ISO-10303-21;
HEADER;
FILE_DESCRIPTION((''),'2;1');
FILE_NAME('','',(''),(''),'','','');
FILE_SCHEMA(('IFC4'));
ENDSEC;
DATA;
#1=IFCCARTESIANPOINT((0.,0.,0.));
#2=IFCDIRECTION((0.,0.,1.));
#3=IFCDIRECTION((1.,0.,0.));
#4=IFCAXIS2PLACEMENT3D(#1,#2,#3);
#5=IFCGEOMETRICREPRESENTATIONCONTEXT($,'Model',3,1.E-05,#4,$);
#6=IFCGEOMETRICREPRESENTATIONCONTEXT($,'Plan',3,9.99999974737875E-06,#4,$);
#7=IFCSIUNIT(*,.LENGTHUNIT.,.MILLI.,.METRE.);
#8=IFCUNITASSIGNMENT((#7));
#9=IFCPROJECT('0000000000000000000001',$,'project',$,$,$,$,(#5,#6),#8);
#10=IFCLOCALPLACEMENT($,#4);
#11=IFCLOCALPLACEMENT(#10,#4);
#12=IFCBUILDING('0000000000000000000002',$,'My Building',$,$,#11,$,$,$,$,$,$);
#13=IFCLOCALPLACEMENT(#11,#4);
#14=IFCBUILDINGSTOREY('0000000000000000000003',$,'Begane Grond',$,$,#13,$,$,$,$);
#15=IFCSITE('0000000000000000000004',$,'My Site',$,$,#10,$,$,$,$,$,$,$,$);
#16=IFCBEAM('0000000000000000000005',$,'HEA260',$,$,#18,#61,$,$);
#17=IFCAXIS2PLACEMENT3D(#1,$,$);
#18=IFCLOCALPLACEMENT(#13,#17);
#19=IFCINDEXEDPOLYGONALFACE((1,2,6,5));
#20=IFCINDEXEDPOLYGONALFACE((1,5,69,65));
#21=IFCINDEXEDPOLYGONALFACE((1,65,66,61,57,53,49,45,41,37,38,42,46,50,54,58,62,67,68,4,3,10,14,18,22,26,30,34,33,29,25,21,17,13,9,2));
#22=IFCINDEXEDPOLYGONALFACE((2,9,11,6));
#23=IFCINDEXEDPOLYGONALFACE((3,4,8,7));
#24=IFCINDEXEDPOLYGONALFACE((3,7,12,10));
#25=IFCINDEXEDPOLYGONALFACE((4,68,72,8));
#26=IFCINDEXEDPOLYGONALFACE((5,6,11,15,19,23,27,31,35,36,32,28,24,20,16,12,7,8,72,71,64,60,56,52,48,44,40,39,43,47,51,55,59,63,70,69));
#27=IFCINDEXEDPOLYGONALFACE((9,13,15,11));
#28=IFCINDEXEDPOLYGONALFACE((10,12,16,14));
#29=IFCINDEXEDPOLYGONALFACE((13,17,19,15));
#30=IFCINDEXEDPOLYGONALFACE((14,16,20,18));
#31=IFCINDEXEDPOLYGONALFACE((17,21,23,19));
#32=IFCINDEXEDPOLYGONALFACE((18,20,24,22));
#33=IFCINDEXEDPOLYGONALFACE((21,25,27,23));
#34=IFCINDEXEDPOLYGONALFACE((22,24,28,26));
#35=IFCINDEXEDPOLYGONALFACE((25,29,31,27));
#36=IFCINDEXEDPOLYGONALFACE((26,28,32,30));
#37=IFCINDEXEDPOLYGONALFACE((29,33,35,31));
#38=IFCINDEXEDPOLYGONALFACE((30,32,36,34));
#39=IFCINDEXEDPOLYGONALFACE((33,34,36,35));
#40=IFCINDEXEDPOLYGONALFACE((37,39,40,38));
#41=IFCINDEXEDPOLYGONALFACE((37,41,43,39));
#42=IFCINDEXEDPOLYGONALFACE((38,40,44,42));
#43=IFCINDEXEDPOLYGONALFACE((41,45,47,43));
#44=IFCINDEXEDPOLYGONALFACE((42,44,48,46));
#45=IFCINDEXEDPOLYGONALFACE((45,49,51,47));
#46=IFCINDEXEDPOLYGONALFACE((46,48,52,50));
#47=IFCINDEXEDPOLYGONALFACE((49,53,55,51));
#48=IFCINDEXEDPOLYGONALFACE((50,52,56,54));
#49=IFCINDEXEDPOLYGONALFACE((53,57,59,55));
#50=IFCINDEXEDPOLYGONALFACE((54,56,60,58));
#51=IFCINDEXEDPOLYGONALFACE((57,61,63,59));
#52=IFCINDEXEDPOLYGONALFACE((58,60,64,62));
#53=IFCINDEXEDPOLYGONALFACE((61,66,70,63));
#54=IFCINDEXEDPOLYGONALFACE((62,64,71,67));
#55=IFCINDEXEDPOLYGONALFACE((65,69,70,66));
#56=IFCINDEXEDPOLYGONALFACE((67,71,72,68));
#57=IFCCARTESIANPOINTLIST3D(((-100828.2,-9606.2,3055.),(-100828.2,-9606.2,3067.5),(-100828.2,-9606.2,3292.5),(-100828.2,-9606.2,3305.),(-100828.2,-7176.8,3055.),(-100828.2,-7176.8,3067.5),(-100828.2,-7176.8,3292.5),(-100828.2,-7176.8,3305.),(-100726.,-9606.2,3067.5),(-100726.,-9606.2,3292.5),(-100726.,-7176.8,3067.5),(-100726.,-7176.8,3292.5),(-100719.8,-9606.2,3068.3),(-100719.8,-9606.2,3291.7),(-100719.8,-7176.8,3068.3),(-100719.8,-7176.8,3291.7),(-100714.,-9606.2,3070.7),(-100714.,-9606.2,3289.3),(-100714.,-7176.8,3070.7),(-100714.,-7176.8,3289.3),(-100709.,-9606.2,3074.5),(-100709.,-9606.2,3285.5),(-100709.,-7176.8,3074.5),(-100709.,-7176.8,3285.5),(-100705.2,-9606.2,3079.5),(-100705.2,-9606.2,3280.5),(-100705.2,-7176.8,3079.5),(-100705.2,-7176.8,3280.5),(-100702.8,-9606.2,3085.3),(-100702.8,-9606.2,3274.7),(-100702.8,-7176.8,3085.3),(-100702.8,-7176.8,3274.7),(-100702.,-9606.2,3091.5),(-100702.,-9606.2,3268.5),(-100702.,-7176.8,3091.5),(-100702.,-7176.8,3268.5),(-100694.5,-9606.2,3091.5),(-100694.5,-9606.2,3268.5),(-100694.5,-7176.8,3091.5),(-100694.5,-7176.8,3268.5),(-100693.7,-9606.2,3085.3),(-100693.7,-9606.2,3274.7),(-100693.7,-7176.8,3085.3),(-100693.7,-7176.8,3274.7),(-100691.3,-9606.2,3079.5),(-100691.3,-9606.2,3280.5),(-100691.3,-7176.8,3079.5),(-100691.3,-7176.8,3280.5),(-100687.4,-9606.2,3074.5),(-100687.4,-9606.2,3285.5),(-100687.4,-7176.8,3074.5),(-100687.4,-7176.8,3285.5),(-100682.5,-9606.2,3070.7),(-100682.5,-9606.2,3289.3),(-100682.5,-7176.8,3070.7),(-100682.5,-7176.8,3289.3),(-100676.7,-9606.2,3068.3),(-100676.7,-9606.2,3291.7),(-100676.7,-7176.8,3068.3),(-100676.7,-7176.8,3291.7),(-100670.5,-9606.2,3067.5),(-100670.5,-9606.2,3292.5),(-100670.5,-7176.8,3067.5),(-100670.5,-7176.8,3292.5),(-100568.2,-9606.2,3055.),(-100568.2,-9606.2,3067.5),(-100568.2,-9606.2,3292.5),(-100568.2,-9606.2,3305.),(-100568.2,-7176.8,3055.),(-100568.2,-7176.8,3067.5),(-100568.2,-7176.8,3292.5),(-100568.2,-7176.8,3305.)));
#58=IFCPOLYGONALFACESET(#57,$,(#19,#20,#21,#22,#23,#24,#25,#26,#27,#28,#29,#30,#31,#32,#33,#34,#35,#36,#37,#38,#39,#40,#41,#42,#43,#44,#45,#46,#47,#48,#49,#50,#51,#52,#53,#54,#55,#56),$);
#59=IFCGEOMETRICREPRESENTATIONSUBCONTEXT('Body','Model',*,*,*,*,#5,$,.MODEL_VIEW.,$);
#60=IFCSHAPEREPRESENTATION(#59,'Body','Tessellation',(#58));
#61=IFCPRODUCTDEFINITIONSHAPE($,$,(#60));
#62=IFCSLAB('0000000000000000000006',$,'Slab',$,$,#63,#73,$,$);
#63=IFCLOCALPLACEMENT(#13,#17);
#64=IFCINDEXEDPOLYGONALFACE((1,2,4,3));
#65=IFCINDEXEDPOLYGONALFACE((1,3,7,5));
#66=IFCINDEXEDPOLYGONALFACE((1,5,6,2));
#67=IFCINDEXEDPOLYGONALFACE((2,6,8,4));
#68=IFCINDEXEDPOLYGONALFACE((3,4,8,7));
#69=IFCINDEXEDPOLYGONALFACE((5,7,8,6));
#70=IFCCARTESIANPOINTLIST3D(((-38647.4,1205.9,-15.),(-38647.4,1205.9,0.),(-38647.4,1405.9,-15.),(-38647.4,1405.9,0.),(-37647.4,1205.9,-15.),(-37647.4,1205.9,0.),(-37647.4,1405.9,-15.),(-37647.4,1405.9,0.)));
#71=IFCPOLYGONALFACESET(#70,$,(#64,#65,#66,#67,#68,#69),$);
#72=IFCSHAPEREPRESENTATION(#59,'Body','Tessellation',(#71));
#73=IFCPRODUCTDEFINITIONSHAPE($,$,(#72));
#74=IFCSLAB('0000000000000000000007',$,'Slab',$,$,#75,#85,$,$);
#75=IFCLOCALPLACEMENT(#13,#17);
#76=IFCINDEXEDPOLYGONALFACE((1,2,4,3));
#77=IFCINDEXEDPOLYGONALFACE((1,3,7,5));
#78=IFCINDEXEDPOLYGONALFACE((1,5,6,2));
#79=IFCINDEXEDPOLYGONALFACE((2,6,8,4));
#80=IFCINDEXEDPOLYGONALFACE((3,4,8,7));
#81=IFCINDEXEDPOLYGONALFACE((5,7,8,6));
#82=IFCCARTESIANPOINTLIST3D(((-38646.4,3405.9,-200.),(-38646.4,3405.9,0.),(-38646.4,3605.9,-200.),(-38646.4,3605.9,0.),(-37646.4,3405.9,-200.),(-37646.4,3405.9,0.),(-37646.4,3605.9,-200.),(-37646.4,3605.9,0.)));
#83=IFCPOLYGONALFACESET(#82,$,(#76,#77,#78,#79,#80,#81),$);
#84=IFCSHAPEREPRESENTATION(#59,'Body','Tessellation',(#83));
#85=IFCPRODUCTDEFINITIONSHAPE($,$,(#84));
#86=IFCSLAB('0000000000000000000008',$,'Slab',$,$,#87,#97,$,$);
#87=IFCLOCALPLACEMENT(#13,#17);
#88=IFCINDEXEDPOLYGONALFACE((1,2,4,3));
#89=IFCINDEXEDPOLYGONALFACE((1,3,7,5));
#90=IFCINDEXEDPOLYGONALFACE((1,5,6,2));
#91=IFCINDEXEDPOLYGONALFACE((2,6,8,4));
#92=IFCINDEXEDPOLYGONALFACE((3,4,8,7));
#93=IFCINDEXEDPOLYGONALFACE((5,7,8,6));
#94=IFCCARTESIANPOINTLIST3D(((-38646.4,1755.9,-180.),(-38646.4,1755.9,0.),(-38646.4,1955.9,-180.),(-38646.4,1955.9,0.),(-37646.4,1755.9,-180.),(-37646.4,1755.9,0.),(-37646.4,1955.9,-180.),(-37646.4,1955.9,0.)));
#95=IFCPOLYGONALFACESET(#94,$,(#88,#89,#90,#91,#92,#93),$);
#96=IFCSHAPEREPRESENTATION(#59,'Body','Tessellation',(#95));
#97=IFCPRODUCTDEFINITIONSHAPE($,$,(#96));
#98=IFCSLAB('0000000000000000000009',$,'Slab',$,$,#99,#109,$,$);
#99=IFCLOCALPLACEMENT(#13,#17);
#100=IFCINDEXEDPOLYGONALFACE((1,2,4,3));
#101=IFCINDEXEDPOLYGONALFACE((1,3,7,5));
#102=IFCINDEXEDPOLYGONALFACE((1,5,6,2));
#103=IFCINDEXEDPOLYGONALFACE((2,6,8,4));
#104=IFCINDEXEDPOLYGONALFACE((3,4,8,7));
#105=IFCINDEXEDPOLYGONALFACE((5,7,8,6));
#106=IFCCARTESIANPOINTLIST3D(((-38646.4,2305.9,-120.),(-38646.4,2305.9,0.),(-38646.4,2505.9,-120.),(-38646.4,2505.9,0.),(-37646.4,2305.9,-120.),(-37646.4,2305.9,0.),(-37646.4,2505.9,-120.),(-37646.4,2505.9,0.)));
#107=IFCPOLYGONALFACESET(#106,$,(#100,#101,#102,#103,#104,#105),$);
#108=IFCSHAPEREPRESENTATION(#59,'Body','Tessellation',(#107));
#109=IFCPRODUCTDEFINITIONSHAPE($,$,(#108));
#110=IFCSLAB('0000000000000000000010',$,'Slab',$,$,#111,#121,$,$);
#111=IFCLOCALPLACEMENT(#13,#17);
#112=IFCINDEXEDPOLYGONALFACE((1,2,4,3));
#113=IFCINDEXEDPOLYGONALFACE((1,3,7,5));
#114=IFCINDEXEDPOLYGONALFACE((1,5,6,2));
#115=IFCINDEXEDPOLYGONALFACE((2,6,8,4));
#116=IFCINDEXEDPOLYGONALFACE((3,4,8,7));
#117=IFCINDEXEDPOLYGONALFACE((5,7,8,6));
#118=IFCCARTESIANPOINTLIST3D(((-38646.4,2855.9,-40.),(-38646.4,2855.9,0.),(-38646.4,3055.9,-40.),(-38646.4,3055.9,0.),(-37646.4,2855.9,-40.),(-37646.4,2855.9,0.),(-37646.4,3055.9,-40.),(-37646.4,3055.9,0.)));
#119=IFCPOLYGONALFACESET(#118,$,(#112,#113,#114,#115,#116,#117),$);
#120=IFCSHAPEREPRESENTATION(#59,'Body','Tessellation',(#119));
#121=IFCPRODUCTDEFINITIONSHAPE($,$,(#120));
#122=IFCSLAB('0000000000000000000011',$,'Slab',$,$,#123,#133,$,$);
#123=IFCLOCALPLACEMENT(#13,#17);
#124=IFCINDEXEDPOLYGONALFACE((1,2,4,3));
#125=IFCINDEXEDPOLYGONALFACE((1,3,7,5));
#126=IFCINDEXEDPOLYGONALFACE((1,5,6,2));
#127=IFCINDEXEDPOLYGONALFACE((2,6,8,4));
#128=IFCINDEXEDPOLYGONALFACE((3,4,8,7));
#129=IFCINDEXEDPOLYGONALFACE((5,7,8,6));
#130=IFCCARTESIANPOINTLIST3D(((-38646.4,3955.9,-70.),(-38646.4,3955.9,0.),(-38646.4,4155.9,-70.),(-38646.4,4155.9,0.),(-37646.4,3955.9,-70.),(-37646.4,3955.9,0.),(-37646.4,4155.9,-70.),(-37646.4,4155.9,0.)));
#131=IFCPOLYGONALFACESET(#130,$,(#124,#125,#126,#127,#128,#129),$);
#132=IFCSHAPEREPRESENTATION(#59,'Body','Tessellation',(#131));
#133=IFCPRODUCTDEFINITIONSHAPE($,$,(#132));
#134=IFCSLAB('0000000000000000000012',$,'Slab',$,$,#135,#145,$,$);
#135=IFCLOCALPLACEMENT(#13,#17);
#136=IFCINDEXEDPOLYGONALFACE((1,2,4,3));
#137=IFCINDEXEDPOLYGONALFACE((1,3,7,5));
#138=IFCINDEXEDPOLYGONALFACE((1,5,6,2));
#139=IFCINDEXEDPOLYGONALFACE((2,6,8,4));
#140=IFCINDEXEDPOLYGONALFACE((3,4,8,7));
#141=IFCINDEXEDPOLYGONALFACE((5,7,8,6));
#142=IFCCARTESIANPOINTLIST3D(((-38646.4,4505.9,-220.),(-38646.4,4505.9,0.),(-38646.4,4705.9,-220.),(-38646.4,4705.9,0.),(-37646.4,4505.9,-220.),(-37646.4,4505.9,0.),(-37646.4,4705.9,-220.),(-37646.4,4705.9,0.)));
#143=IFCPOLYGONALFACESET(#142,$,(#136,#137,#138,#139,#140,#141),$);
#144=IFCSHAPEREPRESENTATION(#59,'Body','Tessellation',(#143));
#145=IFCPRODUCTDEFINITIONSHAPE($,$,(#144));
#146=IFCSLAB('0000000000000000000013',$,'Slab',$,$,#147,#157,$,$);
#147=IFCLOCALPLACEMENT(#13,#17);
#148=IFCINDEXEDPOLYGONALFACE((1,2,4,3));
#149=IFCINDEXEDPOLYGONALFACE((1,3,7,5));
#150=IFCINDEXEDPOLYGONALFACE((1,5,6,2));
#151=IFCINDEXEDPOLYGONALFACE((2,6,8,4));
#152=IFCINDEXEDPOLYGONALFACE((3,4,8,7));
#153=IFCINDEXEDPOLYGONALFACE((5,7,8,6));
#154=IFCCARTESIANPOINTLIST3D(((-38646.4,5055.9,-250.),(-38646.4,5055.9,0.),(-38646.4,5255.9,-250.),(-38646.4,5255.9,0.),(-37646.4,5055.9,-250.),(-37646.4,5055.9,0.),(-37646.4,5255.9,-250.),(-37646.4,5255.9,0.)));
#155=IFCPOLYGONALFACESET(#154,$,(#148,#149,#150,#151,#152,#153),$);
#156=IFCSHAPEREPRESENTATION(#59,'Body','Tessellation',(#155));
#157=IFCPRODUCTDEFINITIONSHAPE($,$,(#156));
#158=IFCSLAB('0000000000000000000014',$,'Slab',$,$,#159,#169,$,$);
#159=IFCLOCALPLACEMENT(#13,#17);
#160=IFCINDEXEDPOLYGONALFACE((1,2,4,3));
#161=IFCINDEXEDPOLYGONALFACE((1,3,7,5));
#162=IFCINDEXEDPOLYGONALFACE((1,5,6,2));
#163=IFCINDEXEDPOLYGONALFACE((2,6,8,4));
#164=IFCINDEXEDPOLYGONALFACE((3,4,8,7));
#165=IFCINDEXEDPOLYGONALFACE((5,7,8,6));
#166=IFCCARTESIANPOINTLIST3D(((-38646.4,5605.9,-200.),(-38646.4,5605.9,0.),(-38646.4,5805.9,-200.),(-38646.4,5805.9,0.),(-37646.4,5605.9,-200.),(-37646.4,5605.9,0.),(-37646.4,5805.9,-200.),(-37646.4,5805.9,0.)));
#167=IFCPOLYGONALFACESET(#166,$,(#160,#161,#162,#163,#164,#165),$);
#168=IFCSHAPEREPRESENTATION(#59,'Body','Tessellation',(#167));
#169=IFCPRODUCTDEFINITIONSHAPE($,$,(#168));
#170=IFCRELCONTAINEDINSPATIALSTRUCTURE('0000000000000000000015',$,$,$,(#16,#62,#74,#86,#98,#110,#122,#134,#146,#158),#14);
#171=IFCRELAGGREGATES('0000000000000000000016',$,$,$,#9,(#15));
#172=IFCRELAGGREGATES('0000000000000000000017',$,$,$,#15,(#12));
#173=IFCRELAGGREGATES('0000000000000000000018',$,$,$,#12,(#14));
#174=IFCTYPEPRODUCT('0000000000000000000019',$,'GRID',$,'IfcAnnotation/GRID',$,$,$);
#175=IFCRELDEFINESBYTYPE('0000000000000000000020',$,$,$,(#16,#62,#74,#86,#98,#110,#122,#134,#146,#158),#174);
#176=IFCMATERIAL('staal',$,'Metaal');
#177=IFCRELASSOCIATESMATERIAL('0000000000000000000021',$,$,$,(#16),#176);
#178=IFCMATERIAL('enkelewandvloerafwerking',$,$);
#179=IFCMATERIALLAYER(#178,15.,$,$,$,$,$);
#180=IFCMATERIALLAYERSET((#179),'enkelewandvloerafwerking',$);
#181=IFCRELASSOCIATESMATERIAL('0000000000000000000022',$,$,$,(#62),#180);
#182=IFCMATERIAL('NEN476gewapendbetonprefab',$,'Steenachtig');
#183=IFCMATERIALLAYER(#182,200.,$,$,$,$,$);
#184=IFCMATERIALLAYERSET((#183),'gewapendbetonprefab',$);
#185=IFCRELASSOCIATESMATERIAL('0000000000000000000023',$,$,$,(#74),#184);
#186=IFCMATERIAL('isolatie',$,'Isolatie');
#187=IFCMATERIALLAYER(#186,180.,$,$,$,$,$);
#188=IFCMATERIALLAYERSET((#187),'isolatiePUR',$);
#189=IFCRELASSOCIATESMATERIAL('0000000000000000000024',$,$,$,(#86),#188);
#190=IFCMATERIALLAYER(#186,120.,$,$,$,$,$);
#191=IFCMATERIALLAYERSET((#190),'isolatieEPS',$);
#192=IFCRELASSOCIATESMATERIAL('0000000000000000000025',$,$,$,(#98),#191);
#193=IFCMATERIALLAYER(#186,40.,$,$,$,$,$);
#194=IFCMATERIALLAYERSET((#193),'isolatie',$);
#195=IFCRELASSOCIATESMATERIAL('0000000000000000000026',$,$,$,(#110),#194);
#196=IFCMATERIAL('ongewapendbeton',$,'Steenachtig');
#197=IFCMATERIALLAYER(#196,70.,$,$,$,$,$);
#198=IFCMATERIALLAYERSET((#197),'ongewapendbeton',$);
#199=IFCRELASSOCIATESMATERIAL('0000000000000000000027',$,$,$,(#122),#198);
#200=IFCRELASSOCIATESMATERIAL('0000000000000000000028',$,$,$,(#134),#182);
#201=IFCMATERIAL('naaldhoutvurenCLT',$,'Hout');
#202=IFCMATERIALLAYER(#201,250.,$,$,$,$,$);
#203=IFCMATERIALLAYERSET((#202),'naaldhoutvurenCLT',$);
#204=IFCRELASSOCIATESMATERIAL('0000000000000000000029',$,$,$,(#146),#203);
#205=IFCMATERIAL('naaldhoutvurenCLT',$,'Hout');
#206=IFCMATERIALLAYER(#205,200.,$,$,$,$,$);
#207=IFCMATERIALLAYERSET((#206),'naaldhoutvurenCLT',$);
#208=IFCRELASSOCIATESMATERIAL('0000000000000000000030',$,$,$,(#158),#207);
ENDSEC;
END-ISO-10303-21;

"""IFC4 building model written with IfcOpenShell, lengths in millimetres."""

from ifc_helpers import new_model, si_unit, frame, origin_with_axes, place, context, subcontext, project, spatial, line, indexed_curve, i_section, outline, extrude, material, layer, layer_set, layer_usage, material_profile, profile_set, profile_usage, type_object, element, save


model = new_model("IFC4")

# Units and contexts
model_context = context("Model", 3, precision=1e-05, world=origin_with_axes())
plan_context = context("Plan", 3, precision=9.99999974737875e-06, world=origin_with_axes())
body_context = subcontext(model_context, "Body", "Model", "MODEL_VIEW")
ifc_project = project(units=[si_unit("LENGTHUNIT", "METRE", prefix="MILLI")], contexts=[model_context, plan_context])

# Site, building, storey
site_placement = place(None, frame((0.0, 0.0, 0.0), z_axis=(0.0, 0.0, 1.0), x_axis=(1.0, 0.0, 0.0)))
site = spatial("IfcSite", under=ifc_project, at=site_placement, Name="My Site")
building_placement = place(site_placement, origin_with_axes())
building = spatial("IfcBuilding", under=site, at=building_placement, Name="My Building")
storey_placement = place(building_placement, origin_with_axes())
storey = spatial("IfcBuildingStorey", under=building, at=storey_placement, Name="Begane Grond")

# Beam
ifc_material_1 = material(Name="staal", Category="Metaal")
ifc_material_profile = material_profile(ifc_material_1, i_section(OverallWidth=260.0, OverallDepth=250.0, WebThickness=7.5, FlangeThickness=12.5, FilletRadius=24.0))
ifc_profile_set = profile_set([ifc_material_profile], Name="HEA260")
ifc_profile_usage = profile_usage(ifc_profile_set, cardinal=5)
type_product = type_object("IfcTypeProduct", Name="GRID", ApplicableOccurrence="IfcAnnotation/GRID")
beam_placement = place(storey_placement, frame((-100698.2, -9606.2, 3180.0), z_axis=(0.0, 1.0, 0.0), x_axis=(-1.0, 0.0, 0.0)))
element("IfcBeam", 1, at=beam_placement, inside=storey, type_object=type_product, material=ifc_profile_usage, Name="HEA260", context=body_context, shape_type="SweptSolid", body=[
    extrude(i_section(OverallWidth=260.0, OverallDepth=250.0, WebThickness=7.5, FlangeThickness=12.5, FilletRadius=24.0), origin_with_axes(), (0.0, 0.0, 1.0), 2429.4),
])

# Slabs
ifc_material_2 = material(Name="naaldhoutvurenCLT", Category="Hout")
ifc_material_3 = material(Name="enkelewandvloerafwerking")
ifc_layer_1 = layer(ifc_material_3, 15.0)
ifc_layer_set_1 = layer_set([ifc_layer_1], Name="enkelewandvloerafwerking")
ifc_layer_usage_1 = layer_usage(ifc_layer_set_1, "AXIS3", "POSITIVE", 0.0)
slab_1_placement = place(storey_placement, frame((-38647.4, 1205.9, -15.0), z_axis=(0.0, 0.0, 1.0), x_axis=(1.0, 0.0, 0.0)))
element("IfcSlab", 2, at=slab_1_placement, inside=storey, type_object=type_product, material=ifc_layer_usage_1, Name="Slab", context=body_context, shape_type="SweptSolid", body=[
    extrude(outline(indexed_curve([(1000.0, 200.0), (1000.0, 0.0), (0.0, 0.0), (0.0, 200.0)], segments=[line(4, 1), line(1, 2), line(2, 3), line(3, 4)], self_intersect=False)), None, (0.0, 0.0, 1.0), 15.0),
])
ifc_material_4 = material(Name="NEN476gewapendbetonprefab", Category="Steenachtig")
ifc_layer_2 = layer(ifc_material_4, 200.0)
ifc_layer_set_2 = layer_set([ifc_layer_2], Name="gewapendbetonprefab")
ifc_layer_usage_2 = layer_usage(ifc_layer_set_2, "AXIS3", "POSITIVE", 0.0)
slab_2_placement = place(storey_placement, frame((-38646.4, 3405.9, -200.0), z_axis=(0.0, 0.0, 1.0), x_axis=(1.0, 0.0, 0.0)))
element("IfcSlab", 3, at=slab_2_placement, inside=storey, type_object=type_product, material=ifc_layer_usage_2, Name="Slab", context=body_context, shape_type="SweptSolid", body=[
    extrude(outline(indexed_curve([(1000.0, 200.0), (1000.0, 0.0), (0.0, 0.0), (0.0, 200.0)], segments=[line(4, 1), line(1, 2), line(2, 3), line(3, 4)], self_intersect=False)), None, (0.0, 0.0, 1.0), 200.0),
])
ifc_material_5 = material(Name="isolatie", Category="Isolatie")
ifc_layer_3 = layer(ifc_material_5, 180.0)
ifc_layer_set_3 = layer_set([ifc_layer_3], Name="isolatiePUR")
ifc_layer_usage_3 = layer_usage(ifc_layer_set_3, "AXIS3", "POSITIVE", 0.0)
slab_3_placement = place(storey_placement, frame((-38646.4, 1755.9, -180.0), z_axis=(0.0, 0.0, 1.0), x_axis=(1.0, 0.0, 0.0)))
element("IfcSlab", 4, at=slab_3_placement, inside=storey, type_object=type_product, material=ifc_layer_usage_3, Name="Slab", context=body_context, shape_type="SweptSolid", body=[
    extrude(outline(indexed_curve([(1000.0, 200.0), (1000.0, 0.0), (0.0, 0.0), (0.0, 200.0)], segments=[line(4, 1), line(1, 2), line(2, 3), line(3, 4)], self_intersect=False)), None, (0.0, 0.0, 1.0), 180.0),
])
ifc_layer_4 = layer(ifc_material_5, 120.0)
ifc_layer_set_4 = layer_set([ifc_layer_4], Name="isolatieEPS")
ifc_layer_usage_4 = layer_usage(ifc_layer_set_4, "AXIS3", "POSITIVE", 0.0)
slab_4_placement = place(storey_placement, frame((-38646.4, 2305.9, -120.0), z_axis=(0.0, 0.0, 1.0), x_axis=(1.0, 0.0, 0.0)))
element("IfcSlab", 5, at=slab_4_placement, inside=storey, type_object=type_product, material=ifc_layer_usage_4, Name="Slab", context=body_context, shape_type="SweptSolid", body=[
    extrude(outline(indexed_curve([(1000.0, 200.0), (1000.0, 0.0), (0.0, 0.0), (0.0, 200.0)], segments=[line(3, 2), line(2, 1), line(1, 4), line(4, 3)], self_intersect=False)), None, (0.0, 0.0, 1.0), 120.0),
])
ifc_layer_5 = layer(ifc_material_5, 40.0)
ifc_layer_set_5 = layer_set([ifc_layer_5], Name="isolatie")
ifc_layer_usage_5 = layer_usage(ifc_layer_set_5, "AXIS3", "POSITIVE", 0.0)
slab_5_placement = place(storey_placement, frame((-38646.4, 2855.9, -40.0), z_axis=(0.0, 0.0, 1.0), x_axis=(1.0, 0.0, 0.0)))
element("IfcSlab", 6, at=slab_5_placement, inside=storey, type_object=type_product, material=ifc_layer_usage_5, Name="Slab", context=body_context, shape_type="SweptSolid", body=[
    extrude(outline(indexed_curve([(1000.0, 200.0), (1000.0, 0.0), (0.0, 0.0), (0.0, 200.0)], segments=[line(3, 2), line(2, 1), line(1, 4), line(4, 3)], self_intersect=False)), None, (0.0, 0.0, 1.0), 40.0),
])
ifc_material_6 = material(Name="ongewapendbeton", Category="Steenachtig")
ifc_layer_6 = layer(ifc_material_6, 70.0)
ifc_layer_set_6 = layer_set([ifc_layer_6], Name="ongewapendbeton")
ifc_layer_usage_6 = layer_usage(ifc_layer_set_6, "AXIS3", "POSITIVE", 0.0)
slab_6_placement = place(storey_placement, frame((-38646.4, 3955.9, -70.0), z_axis=(0.0, 0.0, 1.0), x_axis=(1.0, 0.0, 0.0)))
element("IfcSlab", 7, at=slab_6_placement, inside=storey, type_object=type_product, material=ifc_layer_usage_6, Name="Slab", context=body_context, shape_type="SweptSolid", body=[
    extrude(outline(indexed_curve([(1000.0, 200.0), (1000.0, 0.0), (0.0, 0.0), (0.0, 200.0)], segments=[line(4, 1), line(1, 2), line(2, 3), line(3, 4)], self_intersect=False)), None, (0.0, 0.0, 1.0), 70.0),
])
slab_7_placement = place(storey_placement, frame((-38646.4, 4505.9, -220.0), z_axis=(0.0, 0.0, 1.0), x_axis=(1.0, 0.0, 0.0)))
element("IfcSlab", 8, at=slab_7_placement, inside=storey, type_object=type_product, material=ifc_material_4, Name="Slab", context=body_context, shape_type="SweptSolid", body=[
    extrude(outline(indexed_curve([(1000.0, 200.0), (1000.0, 0.0), (0.0, 0.0), (0.0, 200.0)], segments=[line(4, 1), line(1, 2), line(2, 3), line(3, 4)], self_intersect=False)), None, (0.0, 0.0, 1.0), 220.0),
])
ifc_material_7 = material(Name="naaldhoutvurenCLT", Category="Hout")
ifc_layer_7 = layer(ifc_material_7, 250.0)
ifc_layer_set_7 = layer_set([ifc_layer_7], Name="naaldhoutvurenCLT")
ifc_layer_usage_7 = layer_usage(ifc_layer_set_7, "AXIS3", "POSITIVE", 0.0)
slab_8_placement = place(storey_placement, frame((-38646.4, 5055.9, -250.0), z_axis=(0.0, 0.0, 1.0), x_axis=(1.0, 0.0, 0.0)))
element("IfcSlab", 9, at=slab_8_placement, inside=storey, type_object=type_product, material=ifc_layer_usage_7, Name="Slab", context=body_context, shape_type="SweptSolid", body=[
    extrude(outline(indexed_curve([(1000.0, 200.0), (1000.0, 0.0), (0.0, 0.0), (0.0, 200.0)], segments=[line(3, 2), line(2, 1), line(1, 4), line(4, 3)], self_intersect=False)), None, (0.0, 0.0, 1.0), 250.0),
])
ifc_layer_8 = layer(ifc_material_2, 200.0)
ifc_layer_set_8 = layer_set([ifc_layer_8], Name="naaldhoutvurenCLT")
ifc_layer_usage_8 = layer_usage(ifc_layer_set_8, "AXIS3", "POSITIVE", 0.0)
slab_9_placement = place(storey_placement, frame((-38646.4, 5605.9, -200.0), z_axis=(0.0, 0.0, 1.0), x_axis=(1.0, 0.0, 0.0)))
element("IfcSlab", 10, at=slab_9_placement, inside=storey, type_object=type_product, material=ifc_layer_usage_8, Name="Slab", context=body_context, shape_type="SweptSolid", body=[
    extrude(outline(indexed_curve([(1000.0, 200.0), (1000.0, 0.0), (0.0, 0.0), (0.0, 200.0)], segments=[line(3, 2), line(2, 1), line(1, 4), line(4, 3)], self_intersect=False)), None, (0.0, 0.0, 1.0), 200.0),
])

save(model, "model.ifc")
